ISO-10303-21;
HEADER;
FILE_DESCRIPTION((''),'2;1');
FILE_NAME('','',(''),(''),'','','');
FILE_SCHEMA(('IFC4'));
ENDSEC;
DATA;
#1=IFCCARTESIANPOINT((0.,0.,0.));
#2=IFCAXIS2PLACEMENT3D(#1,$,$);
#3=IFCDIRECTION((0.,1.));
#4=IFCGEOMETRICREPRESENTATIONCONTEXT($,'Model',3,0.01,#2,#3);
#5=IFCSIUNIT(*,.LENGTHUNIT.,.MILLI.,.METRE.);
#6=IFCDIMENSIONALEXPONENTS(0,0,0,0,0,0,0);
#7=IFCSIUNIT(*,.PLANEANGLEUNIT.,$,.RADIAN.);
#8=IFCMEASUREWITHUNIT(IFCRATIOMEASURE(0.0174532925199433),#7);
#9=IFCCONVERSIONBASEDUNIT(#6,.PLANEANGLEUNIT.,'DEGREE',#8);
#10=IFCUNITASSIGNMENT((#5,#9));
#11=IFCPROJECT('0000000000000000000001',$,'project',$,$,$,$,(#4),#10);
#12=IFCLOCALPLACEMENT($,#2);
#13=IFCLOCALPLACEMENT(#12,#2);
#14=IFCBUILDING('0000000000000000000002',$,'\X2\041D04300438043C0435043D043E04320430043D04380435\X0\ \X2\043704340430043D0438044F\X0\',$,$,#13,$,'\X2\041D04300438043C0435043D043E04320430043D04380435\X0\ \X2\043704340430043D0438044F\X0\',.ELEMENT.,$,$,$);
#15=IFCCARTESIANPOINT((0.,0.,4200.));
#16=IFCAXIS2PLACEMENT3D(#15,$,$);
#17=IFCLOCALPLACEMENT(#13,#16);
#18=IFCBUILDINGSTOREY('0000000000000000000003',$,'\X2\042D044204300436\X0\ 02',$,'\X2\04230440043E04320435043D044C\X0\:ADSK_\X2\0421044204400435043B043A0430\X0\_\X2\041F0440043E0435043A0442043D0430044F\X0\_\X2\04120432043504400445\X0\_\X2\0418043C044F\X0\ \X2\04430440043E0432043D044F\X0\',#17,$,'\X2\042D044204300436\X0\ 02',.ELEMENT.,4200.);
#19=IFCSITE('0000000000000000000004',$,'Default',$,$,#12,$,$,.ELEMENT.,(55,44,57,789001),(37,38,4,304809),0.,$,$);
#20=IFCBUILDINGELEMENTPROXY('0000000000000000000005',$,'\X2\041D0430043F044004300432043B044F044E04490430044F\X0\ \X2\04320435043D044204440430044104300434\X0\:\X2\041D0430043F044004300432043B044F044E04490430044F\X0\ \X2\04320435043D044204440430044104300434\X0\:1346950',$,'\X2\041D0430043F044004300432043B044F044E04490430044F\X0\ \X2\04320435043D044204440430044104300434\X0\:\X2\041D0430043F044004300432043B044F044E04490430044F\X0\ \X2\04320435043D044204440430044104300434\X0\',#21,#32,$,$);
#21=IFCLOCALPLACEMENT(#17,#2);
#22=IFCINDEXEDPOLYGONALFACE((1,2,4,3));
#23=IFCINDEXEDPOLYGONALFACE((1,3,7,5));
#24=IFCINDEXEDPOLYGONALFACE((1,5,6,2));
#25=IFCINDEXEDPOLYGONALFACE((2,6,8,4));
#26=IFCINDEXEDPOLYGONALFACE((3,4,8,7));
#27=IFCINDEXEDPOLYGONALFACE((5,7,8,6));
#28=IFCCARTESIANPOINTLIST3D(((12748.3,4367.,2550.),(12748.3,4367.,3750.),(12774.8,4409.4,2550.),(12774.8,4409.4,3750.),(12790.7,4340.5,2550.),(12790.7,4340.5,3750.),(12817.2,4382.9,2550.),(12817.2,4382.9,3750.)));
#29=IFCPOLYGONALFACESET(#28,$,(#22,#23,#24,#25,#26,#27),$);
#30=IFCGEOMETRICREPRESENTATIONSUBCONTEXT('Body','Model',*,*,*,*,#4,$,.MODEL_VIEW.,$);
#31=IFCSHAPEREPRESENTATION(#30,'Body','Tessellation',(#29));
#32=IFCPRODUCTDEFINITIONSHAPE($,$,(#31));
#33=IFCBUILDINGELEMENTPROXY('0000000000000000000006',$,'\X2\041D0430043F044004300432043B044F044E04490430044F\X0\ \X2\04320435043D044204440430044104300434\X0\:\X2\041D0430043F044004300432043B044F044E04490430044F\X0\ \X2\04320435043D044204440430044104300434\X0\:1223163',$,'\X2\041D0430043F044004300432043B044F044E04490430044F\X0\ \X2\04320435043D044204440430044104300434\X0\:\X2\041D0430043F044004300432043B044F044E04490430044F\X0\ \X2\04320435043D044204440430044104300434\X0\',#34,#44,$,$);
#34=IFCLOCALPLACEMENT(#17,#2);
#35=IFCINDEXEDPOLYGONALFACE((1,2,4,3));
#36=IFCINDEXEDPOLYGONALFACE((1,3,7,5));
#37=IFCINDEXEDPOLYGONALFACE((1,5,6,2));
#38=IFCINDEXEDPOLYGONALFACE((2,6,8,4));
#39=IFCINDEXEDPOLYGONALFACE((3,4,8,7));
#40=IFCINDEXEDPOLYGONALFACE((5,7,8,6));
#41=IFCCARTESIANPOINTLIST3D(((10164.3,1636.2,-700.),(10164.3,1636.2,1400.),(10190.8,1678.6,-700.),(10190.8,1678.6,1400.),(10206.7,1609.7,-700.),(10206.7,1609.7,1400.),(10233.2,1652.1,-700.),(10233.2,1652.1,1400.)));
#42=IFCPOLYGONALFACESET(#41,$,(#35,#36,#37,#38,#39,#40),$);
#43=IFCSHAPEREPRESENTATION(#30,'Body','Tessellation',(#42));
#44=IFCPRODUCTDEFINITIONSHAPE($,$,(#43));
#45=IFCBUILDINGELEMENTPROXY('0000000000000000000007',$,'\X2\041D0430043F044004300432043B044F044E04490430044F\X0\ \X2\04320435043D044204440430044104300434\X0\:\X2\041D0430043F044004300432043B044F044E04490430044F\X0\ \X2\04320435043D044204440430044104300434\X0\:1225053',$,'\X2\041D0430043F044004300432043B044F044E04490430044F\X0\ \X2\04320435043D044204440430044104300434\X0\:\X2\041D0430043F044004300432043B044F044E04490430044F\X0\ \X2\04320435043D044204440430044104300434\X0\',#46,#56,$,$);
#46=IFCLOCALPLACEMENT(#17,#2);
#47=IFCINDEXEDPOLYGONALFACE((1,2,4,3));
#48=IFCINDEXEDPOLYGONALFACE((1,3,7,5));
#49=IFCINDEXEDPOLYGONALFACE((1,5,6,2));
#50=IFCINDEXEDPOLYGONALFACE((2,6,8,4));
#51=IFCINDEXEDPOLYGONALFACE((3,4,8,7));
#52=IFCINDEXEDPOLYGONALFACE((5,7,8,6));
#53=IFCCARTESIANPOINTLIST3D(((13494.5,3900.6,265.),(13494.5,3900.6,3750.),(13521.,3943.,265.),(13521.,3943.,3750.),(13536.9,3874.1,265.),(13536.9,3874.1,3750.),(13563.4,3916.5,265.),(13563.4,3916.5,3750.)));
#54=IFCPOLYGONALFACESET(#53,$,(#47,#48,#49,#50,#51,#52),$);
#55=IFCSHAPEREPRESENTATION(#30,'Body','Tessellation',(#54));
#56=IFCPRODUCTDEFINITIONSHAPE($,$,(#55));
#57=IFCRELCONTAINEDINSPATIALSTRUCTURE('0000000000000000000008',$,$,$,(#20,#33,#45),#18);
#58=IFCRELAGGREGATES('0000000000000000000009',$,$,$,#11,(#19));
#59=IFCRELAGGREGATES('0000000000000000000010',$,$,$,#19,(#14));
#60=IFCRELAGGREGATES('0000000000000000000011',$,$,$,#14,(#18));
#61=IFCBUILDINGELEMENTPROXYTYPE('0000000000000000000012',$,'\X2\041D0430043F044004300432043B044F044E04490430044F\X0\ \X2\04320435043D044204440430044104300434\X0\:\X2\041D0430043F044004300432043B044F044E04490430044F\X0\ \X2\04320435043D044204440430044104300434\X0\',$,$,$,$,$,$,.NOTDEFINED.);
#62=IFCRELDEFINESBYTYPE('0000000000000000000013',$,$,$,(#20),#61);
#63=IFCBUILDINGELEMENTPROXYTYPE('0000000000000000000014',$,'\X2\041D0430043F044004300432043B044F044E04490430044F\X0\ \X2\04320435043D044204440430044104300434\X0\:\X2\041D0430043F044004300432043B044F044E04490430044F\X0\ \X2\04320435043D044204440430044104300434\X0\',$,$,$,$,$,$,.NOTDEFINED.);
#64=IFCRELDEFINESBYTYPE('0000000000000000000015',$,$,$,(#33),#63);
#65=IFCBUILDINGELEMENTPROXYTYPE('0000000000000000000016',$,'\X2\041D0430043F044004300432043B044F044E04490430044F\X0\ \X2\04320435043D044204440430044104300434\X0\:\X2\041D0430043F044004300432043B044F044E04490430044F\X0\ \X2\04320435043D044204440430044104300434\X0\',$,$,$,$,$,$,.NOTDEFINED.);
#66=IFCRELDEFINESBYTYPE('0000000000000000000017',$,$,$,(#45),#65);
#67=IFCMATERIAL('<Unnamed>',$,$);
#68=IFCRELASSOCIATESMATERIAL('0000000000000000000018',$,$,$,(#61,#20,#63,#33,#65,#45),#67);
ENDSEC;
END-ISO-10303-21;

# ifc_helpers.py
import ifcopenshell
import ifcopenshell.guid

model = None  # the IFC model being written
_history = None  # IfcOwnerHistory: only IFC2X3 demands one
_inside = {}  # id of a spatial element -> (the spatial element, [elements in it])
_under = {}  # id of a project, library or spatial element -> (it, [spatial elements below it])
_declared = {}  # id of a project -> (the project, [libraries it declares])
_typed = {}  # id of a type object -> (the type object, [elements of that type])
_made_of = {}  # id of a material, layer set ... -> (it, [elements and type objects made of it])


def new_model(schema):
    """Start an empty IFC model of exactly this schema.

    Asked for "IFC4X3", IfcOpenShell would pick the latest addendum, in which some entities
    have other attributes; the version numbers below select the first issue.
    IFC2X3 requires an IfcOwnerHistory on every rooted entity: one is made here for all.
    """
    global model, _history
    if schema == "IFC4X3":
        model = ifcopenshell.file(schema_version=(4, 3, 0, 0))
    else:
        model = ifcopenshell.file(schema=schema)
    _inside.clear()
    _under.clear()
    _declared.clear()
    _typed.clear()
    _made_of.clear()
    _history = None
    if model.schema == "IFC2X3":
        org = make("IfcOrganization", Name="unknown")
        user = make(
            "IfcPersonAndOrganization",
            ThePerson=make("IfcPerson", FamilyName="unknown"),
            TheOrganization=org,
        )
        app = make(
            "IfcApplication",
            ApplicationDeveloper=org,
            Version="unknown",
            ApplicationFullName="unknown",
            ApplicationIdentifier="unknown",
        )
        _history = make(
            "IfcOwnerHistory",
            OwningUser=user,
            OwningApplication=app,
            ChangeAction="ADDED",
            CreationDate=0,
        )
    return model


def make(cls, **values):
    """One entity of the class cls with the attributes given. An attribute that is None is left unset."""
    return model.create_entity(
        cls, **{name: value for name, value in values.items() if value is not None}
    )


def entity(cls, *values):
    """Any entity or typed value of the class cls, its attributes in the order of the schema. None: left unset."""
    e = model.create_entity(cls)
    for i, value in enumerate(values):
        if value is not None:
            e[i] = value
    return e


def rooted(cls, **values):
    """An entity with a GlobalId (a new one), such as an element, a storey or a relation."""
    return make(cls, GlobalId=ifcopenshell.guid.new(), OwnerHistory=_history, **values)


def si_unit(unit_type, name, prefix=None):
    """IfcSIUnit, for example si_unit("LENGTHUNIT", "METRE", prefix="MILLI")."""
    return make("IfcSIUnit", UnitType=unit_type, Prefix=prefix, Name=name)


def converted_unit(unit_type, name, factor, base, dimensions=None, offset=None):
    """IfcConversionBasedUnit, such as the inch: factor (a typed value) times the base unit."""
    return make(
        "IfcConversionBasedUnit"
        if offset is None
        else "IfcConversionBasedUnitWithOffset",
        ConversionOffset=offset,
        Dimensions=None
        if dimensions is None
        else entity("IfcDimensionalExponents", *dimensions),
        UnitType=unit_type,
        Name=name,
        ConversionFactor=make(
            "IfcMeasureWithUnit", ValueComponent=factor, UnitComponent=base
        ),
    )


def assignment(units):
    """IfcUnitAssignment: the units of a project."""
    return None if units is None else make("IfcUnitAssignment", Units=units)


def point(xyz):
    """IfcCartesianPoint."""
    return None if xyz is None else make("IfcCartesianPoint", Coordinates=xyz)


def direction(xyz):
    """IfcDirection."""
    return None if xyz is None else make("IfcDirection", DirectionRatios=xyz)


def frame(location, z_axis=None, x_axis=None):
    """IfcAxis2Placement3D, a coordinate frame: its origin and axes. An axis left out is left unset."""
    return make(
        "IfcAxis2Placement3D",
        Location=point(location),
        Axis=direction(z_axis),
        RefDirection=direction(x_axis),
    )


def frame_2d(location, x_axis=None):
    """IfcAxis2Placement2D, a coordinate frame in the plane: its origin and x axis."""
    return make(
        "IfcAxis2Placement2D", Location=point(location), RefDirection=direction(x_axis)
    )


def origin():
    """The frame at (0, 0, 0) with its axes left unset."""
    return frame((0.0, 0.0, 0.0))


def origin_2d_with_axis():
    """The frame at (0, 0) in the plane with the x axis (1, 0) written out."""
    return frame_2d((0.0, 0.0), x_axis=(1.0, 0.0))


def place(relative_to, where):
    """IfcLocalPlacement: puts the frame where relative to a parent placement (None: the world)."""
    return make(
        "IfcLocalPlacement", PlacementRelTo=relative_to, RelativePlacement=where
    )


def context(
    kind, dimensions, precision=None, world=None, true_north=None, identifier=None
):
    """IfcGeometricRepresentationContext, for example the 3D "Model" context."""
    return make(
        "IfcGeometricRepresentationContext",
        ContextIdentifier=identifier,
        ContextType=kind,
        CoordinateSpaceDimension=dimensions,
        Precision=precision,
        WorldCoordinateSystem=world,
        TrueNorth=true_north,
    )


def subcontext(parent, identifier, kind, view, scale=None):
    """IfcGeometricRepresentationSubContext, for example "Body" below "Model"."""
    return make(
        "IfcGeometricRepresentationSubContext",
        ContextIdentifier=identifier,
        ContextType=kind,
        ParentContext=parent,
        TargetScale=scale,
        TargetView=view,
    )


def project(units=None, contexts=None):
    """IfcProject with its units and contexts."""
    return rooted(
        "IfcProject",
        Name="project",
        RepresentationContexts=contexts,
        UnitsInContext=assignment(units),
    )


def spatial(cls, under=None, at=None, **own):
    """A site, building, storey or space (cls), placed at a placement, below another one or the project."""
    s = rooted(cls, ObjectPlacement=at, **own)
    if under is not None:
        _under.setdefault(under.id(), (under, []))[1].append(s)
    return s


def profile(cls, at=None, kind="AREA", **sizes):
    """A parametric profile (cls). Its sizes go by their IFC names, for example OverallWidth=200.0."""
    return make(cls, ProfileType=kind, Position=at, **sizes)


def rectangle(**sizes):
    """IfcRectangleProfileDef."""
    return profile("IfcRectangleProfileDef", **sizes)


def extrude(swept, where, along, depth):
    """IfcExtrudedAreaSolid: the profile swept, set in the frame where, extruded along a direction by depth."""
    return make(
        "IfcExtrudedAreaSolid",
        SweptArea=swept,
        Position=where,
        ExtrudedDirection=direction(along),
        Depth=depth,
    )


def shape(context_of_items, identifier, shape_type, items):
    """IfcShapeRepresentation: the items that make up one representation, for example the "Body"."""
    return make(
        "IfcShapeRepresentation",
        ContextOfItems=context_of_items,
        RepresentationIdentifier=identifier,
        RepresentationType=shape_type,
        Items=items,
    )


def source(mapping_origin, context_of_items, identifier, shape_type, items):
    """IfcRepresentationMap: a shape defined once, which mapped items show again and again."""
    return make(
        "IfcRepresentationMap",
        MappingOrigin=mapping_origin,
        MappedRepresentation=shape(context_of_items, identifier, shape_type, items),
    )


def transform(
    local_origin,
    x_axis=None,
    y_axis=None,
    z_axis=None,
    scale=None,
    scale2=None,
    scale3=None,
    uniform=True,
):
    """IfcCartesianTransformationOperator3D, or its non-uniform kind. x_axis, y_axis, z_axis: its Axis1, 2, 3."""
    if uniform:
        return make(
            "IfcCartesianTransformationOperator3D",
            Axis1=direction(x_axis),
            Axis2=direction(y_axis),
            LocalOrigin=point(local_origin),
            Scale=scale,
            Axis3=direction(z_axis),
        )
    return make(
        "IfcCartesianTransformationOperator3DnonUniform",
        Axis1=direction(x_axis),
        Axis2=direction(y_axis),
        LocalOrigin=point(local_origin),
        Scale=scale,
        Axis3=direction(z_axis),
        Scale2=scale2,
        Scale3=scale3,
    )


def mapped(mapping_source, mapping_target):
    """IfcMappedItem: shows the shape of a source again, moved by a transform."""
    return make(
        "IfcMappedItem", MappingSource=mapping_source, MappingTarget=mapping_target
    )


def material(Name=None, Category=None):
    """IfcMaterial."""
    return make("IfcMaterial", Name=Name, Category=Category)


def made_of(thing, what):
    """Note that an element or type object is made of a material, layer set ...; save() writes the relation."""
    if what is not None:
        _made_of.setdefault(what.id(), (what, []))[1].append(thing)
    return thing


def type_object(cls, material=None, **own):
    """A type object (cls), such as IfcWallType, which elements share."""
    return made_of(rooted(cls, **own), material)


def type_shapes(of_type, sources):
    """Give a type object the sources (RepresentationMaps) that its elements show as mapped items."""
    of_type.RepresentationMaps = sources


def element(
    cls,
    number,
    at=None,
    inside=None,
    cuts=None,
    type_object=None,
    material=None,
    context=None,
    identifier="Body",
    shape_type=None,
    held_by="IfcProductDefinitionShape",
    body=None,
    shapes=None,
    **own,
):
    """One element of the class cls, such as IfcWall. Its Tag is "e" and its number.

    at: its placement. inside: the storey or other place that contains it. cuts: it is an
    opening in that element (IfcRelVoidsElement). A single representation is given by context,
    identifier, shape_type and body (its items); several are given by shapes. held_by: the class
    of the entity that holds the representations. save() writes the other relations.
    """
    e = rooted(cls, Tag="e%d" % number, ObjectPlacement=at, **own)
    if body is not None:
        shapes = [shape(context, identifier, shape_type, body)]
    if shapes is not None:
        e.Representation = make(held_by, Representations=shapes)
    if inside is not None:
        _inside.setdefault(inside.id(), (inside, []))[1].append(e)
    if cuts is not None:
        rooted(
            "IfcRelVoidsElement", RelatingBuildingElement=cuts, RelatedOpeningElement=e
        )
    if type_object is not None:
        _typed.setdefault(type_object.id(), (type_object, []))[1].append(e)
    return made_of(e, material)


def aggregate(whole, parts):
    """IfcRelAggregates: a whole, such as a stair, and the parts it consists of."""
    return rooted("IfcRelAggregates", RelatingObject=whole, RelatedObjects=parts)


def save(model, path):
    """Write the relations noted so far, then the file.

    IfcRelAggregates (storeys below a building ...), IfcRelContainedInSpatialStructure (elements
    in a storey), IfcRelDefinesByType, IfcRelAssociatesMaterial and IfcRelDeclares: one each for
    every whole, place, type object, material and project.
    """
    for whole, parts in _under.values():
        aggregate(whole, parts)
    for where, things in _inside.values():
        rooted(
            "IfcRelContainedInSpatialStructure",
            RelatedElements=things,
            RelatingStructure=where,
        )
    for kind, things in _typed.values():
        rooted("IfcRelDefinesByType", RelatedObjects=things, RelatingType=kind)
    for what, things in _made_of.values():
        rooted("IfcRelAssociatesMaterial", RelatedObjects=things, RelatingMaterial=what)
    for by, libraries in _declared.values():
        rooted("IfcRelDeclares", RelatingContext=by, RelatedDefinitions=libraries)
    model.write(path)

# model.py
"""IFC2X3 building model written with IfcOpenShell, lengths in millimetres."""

from ifc_helpers import new_model, entity, si_unit, converted_unit, direction, frame, origin, origin_2d_with_axis, place, context, subcontext, project, spatial, rectangle, extrude, source, transform, mapped, material, type_object, type_shapes, element, save


model = new_model("IFC2X3")

# Units and contexts
model_context = context("Model", 3, precision=0.01, world=origin(), true_north=direction((0.0, 1.0)))
body_context = subcontext(model_context, "Body", "Model", "MODEL_VIEW")
ifc_project = project(units=[si_unit("LENGTHUNIT", "METRE", prefix="MILLI"), converted_unit("PLANEANGLEUNIT", "DEGREE", entity("IfcRatioMeasure", 0.0174532925199433), si_unit("PLANEANGLEUNIT", "RADIAN"), dimensions=[0, 0, 0, 0, 0, 0, 0])], contexts=[model_context])

# Site, building, storey
site_placement = place(None, origin())
site = spatial("IfcSite", under=ifc_project, at=site_placement, Name="Default", CompositionType="ELEMENT", RefLatitude=(55, 44, 57, 789001), RefLongitude=(37, 38, 4, 304809), RefElevation=0.0)
building_placement = place(site_placement, origin())
building = spatial("IfcBuilding", under=site, at=building_placement, Name="Наименование здания", LongName="Наименование здания", CompositionType="ELEMENT")
storey_placement = place(building_placement, frame((0.0, 0.0, 4200.0)))
storey = spatial("IfcBuildingStorey", under=building, at=storey_placement, Name="Этаж 02", ObjectType="Уровень:ADSK_Стрелка_Проектная_Вверх_Имя уровня", LongName="Этаж 02", CompositionType="ELEMENT", Elevation=4200.0)

# Building element proxies
ifc_material_1 = material(Name="<Unnamed>")
building_element_proxy_type_1 = type_object("IfcBuildingElementProxyType", Name="Направляющая вентфасад:Направляющая вентфасад", PredefinedType="NOTDEFINED", material=ifc_material_1)
shared_shape_1 = source(origin(), body_context, "Body", "SweptSolid", [
    extrude(rectangle(XDim=50.0, YDim=50.0, at=origin_2d_with_axis()), frame((25.0, -25.0, 0.0), z_axis=(0.0, 0.0, 1.0), x_axis=(-1.0, 0.0, 0.0)), (0.0, 0.0, 1.0), 1200.0),
])
type_shapes(building_element_proxy_type_1, [shared_shape_1])
proxy_1_placement = place(storey_placement, frame((12774.8, 4409.4, 2550.0), z_axis=(0.0, 0.0, 1.0), x_axis=(0.848053, -0.529912, 0.0)))
element("IfcBuildingElementProxy", 1, at=proxy_1_placement, inside=storey, type_object=building_element_proxy_type_1, material=ifc_material_1, Name="Направляющая вентфасад:Направляющая вентфасад:1346950", ObjectType="Направляющая вентфасад:Направляющая вентфасад", context=body_context, shape_type="MappedRepresentation", body=[
    mapped(shared_shape_1, transform((0.0, 0.0, 0.0), scale=1.0)),
])
building_element_proxy_type_2 = type_object("IfcBuildingElementProxyType", Name="Направляющая вентфасад:Направляющая вентфасад", PredefinedType="NOTDEFINED", material=ifc_material_1)
shared_shape_2 = source(origin(), body_context, "Body", "SweptSolid", [
    extrude(rectangle(XDim=50.0, YDim=50.0, at=origin_2d_with_axis()), frame((25.0, -25.0, 0.0), z_axis=(0.0, 0.0, 1.0), x_axis=(-1.0, 0.0, 0.0)), (0.0, 0.0, 1.0), 2100.0),
])
type_shapes(building_element_proxy_type_2, [shared_shape_2])
proxy_2_placement = place(storey_placement, frame((10190.8, 1678.6, -700.0), z_axis=(0.0, 0.0, 1.0), x_axis=(0.848053, -0.529912, 0.0)))
element("IfcBuildingElementProxy", 2, at=proxy_2_placement, inside=storey, type_object=building_element_proxy_type_2, material=ifc_material_1, Name="Направляющая вентфасад:Направляющая вентфасад:1223163", ObjectType="Направляющая вентфасад:Направляющая вентфасад", context=body_context, shape_type="MappedRepresentation", body=[
    mapped(shared_shape_2, transform((0.0, 0.0, 0.0), scale=1.0)),
])
building_element_proxy_type_3 = type_object("IfcBuildingElementProxyType", Name="Направляющая вентфасад:Направляющая вентфасад", PredefinedType="NOTDEFINED", material=ifc_material_1)
shared_shape_3 = source(origin(), body_context, "Body", "SweptSolid", [
    extrude(rectangle(XDim=50.0, YDim=50.0, at=origin_2d_with_axis()), frame((25.0, 25.0, 0.0), z_axis=(0.0, 0.0, 1.0), x_axis=(0.0, 1.0, 0.0)), (0.0, 0.0, 1.0), 3485.0),
])
type_shapes(building_element_proxy_type_3, [shared_shape_3])
proxy_3_placement = place(storey_placement, frame((13563.4, 3916.5, 265.0), z_axis=(0.0, 0.0, 1.0), x_axis=(-0.848053, 0.529912, 0.0)))
element("IfcBuildingElementProxy", 3, at=proxy_3_placement, inside=storey, type_object=building_element_proxy_type_3, material=ifc_material_1, Name="Направляющая вентфасад:Направляющая вентфасад:1225053", ObjectType="Направляющая вентфасад:Направляющая вентфасад", context=body_context, shape_type="MappedRepresentation", body=[
    mapped(shared_shape_3, transform((0.0, 0.0, 0.0), scale=1.0)),
])

save(model, "model.ifc")
